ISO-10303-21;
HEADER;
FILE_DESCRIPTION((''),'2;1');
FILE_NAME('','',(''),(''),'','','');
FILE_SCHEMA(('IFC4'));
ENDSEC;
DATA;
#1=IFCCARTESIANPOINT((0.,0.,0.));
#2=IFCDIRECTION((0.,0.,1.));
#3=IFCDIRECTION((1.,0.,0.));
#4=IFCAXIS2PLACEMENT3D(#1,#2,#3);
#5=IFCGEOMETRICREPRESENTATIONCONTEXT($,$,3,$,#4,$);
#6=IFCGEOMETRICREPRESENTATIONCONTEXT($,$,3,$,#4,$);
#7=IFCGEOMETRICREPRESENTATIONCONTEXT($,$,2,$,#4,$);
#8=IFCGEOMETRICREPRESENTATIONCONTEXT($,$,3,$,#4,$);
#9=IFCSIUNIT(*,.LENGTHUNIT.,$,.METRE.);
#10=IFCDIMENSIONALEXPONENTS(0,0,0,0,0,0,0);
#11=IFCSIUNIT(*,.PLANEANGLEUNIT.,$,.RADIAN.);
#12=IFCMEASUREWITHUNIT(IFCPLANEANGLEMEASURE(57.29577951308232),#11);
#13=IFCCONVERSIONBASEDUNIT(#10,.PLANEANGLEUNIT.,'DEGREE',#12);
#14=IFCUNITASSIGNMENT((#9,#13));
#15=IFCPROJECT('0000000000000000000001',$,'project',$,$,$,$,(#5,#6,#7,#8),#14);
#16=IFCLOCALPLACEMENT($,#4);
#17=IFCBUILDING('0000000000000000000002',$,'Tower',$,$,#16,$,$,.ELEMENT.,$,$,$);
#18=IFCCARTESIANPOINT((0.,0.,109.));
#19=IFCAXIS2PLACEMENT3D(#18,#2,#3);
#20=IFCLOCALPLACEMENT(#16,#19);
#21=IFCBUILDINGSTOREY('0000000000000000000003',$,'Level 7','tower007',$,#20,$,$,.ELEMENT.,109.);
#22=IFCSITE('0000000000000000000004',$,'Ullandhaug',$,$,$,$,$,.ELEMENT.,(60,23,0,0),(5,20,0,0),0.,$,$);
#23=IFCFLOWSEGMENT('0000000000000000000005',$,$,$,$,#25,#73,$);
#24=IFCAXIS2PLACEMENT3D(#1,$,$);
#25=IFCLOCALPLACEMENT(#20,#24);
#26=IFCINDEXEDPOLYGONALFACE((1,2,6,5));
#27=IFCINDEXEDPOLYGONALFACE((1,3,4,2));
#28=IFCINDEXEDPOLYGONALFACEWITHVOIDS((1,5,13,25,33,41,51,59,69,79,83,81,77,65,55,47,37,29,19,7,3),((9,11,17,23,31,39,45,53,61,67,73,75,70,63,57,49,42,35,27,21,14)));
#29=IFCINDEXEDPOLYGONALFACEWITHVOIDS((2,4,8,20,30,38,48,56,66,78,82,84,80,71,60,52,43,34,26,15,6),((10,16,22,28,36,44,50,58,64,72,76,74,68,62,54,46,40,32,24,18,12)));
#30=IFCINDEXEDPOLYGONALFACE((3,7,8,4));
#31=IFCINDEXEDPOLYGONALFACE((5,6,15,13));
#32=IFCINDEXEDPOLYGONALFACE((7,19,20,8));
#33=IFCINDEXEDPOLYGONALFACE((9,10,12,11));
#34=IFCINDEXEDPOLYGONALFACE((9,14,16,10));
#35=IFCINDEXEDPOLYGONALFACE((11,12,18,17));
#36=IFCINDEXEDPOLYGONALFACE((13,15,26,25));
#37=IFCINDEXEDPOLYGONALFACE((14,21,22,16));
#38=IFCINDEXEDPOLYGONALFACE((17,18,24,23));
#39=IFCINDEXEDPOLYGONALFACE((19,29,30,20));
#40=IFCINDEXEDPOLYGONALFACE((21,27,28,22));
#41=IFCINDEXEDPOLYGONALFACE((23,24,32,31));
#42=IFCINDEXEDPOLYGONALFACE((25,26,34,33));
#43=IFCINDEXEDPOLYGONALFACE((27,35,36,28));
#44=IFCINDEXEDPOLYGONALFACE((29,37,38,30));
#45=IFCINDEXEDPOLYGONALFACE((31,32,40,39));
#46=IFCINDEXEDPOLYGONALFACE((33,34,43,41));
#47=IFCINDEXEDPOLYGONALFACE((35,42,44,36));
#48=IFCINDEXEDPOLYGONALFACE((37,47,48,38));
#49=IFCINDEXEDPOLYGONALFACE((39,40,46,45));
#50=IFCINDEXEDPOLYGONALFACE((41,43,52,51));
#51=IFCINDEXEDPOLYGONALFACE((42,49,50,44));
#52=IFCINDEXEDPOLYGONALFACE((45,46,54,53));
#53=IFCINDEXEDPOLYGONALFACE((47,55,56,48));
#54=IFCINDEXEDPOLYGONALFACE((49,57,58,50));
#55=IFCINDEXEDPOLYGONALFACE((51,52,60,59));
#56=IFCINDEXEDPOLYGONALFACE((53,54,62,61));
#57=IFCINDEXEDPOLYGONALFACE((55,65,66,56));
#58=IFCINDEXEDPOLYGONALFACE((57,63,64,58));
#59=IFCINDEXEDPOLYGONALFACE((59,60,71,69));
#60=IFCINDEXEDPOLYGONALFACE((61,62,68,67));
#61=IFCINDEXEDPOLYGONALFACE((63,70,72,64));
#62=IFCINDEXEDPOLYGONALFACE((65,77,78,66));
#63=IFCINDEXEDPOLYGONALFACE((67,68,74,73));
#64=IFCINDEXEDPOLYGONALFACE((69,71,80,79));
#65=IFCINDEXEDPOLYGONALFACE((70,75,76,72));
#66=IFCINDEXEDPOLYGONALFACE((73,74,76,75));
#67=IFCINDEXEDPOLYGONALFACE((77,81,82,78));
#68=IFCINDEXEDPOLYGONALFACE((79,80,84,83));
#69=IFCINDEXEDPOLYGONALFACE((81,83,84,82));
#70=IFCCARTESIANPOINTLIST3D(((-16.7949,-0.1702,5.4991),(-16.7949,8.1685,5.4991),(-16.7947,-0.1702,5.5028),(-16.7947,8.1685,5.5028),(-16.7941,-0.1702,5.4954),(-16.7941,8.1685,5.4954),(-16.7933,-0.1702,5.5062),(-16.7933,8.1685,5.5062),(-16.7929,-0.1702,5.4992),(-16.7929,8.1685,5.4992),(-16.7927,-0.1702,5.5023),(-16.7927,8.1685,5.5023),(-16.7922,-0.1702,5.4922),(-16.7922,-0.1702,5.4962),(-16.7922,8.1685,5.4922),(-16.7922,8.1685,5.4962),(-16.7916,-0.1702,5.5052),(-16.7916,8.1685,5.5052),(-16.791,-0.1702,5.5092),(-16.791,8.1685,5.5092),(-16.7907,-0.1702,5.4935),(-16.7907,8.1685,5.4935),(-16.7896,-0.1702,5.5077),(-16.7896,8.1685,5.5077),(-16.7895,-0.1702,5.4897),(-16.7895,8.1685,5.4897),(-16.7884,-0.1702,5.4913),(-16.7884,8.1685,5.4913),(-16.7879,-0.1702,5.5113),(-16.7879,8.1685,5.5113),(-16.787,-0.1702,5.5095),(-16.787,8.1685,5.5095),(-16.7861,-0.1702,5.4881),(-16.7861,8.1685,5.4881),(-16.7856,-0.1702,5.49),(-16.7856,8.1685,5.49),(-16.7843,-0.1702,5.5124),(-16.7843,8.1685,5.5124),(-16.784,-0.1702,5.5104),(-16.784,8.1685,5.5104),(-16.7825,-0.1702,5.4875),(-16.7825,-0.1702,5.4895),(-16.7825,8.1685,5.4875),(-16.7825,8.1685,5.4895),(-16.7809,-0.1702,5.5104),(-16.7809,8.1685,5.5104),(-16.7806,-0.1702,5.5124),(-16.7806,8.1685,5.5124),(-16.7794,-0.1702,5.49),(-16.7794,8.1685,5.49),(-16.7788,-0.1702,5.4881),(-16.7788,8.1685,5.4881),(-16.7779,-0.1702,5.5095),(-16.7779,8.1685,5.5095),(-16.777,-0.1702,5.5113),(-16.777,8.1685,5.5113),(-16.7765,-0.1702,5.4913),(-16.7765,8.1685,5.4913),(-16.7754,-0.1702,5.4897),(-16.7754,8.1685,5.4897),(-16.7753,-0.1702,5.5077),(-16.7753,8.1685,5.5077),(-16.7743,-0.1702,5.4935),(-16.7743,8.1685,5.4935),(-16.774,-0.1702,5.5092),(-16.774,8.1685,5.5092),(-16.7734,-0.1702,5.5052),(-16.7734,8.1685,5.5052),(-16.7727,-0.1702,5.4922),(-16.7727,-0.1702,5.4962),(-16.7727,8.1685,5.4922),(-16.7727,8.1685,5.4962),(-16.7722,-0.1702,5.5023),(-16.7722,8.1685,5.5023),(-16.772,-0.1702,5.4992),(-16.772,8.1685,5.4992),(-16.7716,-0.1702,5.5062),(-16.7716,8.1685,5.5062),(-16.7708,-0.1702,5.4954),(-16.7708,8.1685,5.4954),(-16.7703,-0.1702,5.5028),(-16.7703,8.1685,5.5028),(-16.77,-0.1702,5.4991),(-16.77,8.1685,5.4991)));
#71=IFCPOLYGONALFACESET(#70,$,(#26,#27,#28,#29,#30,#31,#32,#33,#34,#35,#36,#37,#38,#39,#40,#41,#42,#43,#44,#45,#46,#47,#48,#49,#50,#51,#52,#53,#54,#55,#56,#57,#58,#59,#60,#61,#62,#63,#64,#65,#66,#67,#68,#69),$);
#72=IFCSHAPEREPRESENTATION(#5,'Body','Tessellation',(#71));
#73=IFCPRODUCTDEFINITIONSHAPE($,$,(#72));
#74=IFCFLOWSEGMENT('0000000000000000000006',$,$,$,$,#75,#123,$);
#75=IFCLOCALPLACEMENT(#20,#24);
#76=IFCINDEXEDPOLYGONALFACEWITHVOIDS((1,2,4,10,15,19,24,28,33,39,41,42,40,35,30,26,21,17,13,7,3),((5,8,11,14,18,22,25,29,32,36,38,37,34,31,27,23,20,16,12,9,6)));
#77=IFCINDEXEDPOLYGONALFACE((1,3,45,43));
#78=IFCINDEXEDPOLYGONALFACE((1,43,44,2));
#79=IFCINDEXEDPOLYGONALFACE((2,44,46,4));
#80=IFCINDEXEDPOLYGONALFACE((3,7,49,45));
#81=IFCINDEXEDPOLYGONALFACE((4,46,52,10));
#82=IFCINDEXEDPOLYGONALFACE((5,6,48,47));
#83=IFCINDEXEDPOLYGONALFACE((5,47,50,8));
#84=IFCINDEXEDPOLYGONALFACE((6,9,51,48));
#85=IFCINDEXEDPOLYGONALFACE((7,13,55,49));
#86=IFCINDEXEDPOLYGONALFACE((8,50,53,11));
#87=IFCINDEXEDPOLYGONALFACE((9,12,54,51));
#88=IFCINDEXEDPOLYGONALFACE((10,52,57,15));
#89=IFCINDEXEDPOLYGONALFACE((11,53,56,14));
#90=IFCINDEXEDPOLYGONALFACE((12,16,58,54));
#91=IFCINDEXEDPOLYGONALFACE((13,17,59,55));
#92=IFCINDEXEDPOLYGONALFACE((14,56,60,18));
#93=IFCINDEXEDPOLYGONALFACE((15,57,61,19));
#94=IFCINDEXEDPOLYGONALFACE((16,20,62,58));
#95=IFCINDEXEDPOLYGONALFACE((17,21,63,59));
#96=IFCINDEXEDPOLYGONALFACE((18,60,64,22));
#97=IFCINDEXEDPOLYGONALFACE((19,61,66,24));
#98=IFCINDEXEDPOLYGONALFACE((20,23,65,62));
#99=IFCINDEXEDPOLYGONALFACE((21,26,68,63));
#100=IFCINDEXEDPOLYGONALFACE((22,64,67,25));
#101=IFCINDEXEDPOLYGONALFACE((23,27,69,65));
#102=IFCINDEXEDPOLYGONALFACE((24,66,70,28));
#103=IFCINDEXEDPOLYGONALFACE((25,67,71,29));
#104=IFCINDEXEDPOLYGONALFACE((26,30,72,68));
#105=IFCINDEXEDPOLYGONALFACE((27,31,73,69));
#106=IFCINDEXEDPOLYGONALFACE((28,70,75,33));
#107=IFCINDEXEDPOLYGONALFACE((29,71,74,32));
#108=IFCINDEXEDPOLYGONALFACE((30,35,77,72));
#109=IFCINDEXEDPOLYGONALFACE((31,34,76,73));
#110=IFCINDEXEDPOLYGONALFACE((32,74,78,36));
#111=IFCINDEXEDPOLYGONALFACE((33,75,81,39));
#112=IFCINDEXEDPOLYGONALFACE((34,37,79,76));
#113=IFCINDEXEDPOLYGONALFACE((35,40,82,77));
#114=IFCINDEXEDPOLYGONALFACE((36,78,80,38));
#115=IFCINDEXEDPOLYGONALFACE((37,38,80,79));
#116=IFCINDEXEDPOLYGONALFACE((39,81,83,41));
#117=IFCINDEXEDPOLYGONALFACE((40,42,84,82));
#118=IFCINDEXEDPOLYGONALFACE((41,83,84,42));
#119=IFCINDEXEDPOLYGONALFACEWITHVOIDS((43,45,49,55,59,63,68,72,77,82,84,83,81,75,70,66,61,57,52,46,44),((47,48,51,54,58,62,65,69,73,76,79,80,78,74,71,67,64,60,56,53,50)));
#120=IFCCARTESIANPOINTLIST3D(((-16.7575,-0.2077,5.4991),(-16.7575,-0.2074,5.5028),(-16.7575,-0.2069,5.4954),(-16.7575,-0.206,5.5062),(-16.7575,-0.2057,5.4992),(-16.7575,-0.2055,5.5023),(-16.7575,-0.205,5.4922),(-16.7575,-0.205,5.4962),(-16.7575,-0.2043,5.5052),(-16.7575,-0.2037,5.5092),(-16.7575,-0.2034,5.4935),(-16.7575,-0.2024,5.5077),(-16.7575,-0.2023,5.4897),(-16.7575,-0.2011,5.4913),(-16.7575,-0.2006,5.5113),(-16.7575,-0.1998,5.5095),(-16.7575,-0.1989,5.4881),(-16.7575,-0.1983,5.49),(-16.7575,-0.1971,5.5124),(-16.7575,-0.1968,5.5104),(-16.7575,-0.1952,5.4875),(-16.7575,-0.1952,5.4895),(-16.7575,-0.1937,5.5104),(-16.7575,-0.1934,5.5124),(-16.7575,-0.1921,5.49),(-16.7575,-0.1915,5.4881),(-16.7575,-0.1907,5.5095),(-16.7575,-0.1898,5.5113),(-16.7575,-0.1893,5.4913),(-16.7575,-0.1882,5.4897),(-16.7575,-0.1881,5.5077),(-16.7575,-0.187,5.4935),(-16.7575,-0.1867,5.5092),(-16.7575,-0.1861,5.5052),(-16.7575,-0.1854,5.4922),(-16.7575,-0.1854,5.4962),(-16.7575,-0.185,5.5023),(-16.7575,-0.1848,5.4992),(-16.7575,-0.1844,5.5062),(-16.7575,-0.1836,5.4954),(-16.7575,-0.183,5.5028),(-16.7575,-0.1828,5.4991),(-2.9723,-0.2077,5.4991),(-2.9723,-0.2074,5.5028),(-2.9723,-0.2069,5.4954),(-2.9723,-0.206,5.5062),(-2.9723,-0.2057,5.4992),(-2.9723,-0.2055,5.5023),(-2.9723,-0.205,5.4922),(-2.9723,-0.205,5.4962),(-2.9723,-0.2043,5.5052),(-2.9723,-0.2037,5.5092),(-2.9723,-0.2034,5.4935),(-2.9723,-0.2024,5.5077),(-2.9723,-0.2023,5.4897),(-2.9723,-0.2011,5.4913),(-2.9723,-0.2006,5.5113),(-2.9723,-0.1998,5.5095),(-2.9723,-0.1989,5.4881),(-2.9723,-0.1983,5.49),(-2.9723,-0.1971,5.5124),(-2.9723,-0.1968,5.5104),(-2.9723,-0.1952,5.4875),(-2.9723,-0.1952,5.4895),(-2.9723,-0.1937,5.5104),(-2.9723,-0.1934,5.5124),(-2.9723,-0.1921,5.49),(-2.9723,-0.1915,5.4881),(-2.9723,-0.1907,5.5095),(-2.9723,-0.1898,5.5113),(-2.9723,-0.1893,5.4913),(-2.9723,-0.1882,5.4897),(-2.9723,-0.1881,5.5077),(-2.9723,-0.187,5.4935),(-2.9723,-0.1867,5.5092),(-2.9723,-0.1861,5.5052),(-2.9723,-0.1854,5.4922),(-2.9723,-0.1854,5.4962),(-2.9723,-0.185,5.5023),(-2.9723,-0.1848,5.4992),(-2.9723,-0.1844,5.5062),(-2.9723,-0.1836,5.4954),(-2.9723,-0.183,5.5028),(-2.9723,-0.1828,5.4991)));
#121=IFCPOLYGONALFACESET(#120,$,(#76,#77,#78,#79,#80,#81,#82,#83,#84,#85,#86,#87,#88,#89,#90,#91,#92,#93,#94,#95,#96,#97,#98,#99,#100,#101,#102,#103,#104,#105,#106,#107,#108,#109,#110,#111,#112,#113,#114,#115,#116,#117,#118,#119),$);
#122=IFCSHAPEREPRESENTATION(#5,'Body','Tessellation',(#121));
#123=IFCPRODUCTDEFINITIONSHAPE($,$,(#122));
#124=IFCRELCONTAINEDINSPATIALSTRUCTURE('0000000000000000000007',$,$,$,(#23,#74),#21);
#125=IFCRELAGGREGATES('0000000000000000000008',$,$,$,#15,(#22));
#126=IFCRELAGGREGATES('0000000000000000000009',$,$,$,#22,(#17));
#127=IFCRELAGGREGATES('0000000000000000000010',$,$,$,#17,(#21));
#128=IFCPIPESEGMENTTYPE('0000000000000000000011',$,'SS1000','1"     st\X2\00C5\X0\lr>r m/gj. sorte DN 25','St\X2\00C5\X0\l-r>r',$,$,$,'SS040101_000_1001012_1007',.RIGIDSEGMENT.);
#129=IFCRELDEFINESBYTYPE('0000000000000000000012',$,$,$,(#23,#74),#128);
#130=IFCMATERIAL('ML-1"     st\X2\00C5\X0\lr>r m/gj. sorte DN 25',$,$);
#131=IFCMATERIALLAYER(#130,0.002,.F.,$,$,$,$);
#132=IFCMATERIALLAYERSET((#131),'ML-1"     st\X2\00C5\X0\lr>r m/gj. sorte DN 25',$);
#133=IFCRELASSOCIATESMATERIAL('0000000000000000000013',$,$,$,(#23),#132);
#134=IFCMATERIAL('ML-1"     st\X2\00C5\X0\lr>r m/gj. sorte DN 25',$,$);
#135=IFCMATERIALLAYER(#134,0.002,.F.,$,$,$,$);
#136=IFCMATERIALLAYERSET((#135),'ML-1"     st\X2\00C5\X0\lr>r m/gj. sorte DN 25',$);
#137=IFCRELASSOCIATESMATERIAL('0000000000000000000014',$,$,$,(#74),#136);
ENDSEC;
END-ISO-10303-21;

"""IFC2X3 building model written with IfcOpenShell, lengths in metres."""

from ifc_helpers import new_model, entity, si_unit, converted_unit, frame, origin_with_axes, origin_2d_with_axis, place, context, project, spatial, hollow_circle, extrude, material, layer, layer_set, layer_usage, type_object, element, save


model = new_model("IFC2X3")

# Units and contexts
context_of_model_1 = context(None, 3, world=origin_with_axes())
context_of_model_2 = context(None, 3, world=origin_with_axes())
context_of_model_3 = context(None, 2, world=origin_with_axes())
context_of_model_4 = context(None, 3, world=origin_with_axes())
ifc_project = project(units=[si_unit("LENGTHUNIT", "METRE"), converted_unit("PLANEANGLEUNIT", "DEGREE", entity("IfcPlaneAngleMeasure", 57.29577951308232), si_unit("PLANEANGLEUNIT", "RADIAN"), dimensions=[0, 0, 0, 0, 0, 0, 0])], contexts=[context_of_model_1, context_of_model_2, context_of_model_3, context_of_model_4])

# Site, building, storey
site = spatial("IfcSite", under=ifc_project, Name="Ullandhaug", CompositionType="ELEMENT", RefLatitude=(60, 23, 0, 0), RefLongitude=(5, 20, 0, 0), RefElevation=0.0)
building_placement = place(None, origin_with_axes())
building = spatial("IfcBuilding", under=site, at=building_placement, Name="Tower", CompositionType="ELEMENT")
storey_placement = place(building_placement, frame((0.0, 0.0, 109.0), z_axis=(0.0, 0.0, 1.0), x_axis=(1.0, 0.0, 0.0)))
storey = spatial("IfcBuildingStorey", under=building, at=storey_placement, Name="Level 7", Description="tower007", CompositionType="ELEMENT", Elevation=109.0)

# Flow segments
ifc_material_1 = material(Name="ML-1\"     stÅlr>r m/gj. sorte DN 25")
ifc_layer_1 = layer(ifc_material_1, 0.002, ventilated=False)
ifc_layer_set_1 = layer_set([ifc_layer_1], Name="ML-1\"     stÅlr>r m/gj. sorte DN 25")
ifc_layer_usage_1 = layer_usage(ifc_layer_set_1, "AXIS2", "POSITIVE", 0.0)
pipe_segment_type_1 = type_object("IfcPipeSegmentType", Name="SS1000", Description="1\"     stÅlr>r m/gj. sorte DN 25", ApplicableOccurrence="StÅl-r>r", ElementType="SS040101_000_1001012_1007", PredefinedType="RIGIDSEGMENT")
flow_segment_1_placement = place(storey_placement, frame((-16.7825, 8.1685, 5.5), z_axis=(0.0, -1.0, 0.0), x_axis=(0.0, 0.0, -1.0)))
element("IfcFlowSegment", 1, at=flow_segment_1_placement, inside=storey, type_object=pipe_segment_type_1, material=ifc_layer_usage_1, context=context_of_model_1, shape_type="SweptSolid", body=[
    extrude(hollow_circle(Radius=0.0125, WallThickness=0.002, at=origin_2d_with_axis()), origin_with_axes(), (0.0, 0.0, 1.0), 8.3387),
])
ifc_material_2 = material(Name="ML-1\"     stÅlr>r m/gj. sorte DN 25")
ifc_layer_2 = layer(ifc_material_2, 0.002, ventilated=False)
ifc_layer_set_2 = layer_set([ifc_layer_2], Name="ML-1\"     stÅlr>r m/gj. sorte DN 25")
ifc_layer_usage_2 = layer_usage(ifc_layer_set_2, "AXIS2", "POSITIVE", 0.0)
flow_segment_2_placement = place(storey_placement, frame((-16.7575, -0.1952, 5.5), z_axis=(1.0, 0.0, 0.0), x_axis=(0.0, 0.0, -1.0)))
element("IfcFlowSegment", 2, at=flow_segment_2_placement, inside=storey, type_object=pipe_segment_type_1, material=ifc_layer_usage_2, context=context_of_model_1, shape_type="SweptSolid", body=[
    extrude(hollow_circle(Radius=0.0125, WallThickness=0.002, at=origin_2d_with_axis()), origin_with_axes(), (0.0, 0.0, 1.0), 13.7851),
])

save(model, "model.ifc")
